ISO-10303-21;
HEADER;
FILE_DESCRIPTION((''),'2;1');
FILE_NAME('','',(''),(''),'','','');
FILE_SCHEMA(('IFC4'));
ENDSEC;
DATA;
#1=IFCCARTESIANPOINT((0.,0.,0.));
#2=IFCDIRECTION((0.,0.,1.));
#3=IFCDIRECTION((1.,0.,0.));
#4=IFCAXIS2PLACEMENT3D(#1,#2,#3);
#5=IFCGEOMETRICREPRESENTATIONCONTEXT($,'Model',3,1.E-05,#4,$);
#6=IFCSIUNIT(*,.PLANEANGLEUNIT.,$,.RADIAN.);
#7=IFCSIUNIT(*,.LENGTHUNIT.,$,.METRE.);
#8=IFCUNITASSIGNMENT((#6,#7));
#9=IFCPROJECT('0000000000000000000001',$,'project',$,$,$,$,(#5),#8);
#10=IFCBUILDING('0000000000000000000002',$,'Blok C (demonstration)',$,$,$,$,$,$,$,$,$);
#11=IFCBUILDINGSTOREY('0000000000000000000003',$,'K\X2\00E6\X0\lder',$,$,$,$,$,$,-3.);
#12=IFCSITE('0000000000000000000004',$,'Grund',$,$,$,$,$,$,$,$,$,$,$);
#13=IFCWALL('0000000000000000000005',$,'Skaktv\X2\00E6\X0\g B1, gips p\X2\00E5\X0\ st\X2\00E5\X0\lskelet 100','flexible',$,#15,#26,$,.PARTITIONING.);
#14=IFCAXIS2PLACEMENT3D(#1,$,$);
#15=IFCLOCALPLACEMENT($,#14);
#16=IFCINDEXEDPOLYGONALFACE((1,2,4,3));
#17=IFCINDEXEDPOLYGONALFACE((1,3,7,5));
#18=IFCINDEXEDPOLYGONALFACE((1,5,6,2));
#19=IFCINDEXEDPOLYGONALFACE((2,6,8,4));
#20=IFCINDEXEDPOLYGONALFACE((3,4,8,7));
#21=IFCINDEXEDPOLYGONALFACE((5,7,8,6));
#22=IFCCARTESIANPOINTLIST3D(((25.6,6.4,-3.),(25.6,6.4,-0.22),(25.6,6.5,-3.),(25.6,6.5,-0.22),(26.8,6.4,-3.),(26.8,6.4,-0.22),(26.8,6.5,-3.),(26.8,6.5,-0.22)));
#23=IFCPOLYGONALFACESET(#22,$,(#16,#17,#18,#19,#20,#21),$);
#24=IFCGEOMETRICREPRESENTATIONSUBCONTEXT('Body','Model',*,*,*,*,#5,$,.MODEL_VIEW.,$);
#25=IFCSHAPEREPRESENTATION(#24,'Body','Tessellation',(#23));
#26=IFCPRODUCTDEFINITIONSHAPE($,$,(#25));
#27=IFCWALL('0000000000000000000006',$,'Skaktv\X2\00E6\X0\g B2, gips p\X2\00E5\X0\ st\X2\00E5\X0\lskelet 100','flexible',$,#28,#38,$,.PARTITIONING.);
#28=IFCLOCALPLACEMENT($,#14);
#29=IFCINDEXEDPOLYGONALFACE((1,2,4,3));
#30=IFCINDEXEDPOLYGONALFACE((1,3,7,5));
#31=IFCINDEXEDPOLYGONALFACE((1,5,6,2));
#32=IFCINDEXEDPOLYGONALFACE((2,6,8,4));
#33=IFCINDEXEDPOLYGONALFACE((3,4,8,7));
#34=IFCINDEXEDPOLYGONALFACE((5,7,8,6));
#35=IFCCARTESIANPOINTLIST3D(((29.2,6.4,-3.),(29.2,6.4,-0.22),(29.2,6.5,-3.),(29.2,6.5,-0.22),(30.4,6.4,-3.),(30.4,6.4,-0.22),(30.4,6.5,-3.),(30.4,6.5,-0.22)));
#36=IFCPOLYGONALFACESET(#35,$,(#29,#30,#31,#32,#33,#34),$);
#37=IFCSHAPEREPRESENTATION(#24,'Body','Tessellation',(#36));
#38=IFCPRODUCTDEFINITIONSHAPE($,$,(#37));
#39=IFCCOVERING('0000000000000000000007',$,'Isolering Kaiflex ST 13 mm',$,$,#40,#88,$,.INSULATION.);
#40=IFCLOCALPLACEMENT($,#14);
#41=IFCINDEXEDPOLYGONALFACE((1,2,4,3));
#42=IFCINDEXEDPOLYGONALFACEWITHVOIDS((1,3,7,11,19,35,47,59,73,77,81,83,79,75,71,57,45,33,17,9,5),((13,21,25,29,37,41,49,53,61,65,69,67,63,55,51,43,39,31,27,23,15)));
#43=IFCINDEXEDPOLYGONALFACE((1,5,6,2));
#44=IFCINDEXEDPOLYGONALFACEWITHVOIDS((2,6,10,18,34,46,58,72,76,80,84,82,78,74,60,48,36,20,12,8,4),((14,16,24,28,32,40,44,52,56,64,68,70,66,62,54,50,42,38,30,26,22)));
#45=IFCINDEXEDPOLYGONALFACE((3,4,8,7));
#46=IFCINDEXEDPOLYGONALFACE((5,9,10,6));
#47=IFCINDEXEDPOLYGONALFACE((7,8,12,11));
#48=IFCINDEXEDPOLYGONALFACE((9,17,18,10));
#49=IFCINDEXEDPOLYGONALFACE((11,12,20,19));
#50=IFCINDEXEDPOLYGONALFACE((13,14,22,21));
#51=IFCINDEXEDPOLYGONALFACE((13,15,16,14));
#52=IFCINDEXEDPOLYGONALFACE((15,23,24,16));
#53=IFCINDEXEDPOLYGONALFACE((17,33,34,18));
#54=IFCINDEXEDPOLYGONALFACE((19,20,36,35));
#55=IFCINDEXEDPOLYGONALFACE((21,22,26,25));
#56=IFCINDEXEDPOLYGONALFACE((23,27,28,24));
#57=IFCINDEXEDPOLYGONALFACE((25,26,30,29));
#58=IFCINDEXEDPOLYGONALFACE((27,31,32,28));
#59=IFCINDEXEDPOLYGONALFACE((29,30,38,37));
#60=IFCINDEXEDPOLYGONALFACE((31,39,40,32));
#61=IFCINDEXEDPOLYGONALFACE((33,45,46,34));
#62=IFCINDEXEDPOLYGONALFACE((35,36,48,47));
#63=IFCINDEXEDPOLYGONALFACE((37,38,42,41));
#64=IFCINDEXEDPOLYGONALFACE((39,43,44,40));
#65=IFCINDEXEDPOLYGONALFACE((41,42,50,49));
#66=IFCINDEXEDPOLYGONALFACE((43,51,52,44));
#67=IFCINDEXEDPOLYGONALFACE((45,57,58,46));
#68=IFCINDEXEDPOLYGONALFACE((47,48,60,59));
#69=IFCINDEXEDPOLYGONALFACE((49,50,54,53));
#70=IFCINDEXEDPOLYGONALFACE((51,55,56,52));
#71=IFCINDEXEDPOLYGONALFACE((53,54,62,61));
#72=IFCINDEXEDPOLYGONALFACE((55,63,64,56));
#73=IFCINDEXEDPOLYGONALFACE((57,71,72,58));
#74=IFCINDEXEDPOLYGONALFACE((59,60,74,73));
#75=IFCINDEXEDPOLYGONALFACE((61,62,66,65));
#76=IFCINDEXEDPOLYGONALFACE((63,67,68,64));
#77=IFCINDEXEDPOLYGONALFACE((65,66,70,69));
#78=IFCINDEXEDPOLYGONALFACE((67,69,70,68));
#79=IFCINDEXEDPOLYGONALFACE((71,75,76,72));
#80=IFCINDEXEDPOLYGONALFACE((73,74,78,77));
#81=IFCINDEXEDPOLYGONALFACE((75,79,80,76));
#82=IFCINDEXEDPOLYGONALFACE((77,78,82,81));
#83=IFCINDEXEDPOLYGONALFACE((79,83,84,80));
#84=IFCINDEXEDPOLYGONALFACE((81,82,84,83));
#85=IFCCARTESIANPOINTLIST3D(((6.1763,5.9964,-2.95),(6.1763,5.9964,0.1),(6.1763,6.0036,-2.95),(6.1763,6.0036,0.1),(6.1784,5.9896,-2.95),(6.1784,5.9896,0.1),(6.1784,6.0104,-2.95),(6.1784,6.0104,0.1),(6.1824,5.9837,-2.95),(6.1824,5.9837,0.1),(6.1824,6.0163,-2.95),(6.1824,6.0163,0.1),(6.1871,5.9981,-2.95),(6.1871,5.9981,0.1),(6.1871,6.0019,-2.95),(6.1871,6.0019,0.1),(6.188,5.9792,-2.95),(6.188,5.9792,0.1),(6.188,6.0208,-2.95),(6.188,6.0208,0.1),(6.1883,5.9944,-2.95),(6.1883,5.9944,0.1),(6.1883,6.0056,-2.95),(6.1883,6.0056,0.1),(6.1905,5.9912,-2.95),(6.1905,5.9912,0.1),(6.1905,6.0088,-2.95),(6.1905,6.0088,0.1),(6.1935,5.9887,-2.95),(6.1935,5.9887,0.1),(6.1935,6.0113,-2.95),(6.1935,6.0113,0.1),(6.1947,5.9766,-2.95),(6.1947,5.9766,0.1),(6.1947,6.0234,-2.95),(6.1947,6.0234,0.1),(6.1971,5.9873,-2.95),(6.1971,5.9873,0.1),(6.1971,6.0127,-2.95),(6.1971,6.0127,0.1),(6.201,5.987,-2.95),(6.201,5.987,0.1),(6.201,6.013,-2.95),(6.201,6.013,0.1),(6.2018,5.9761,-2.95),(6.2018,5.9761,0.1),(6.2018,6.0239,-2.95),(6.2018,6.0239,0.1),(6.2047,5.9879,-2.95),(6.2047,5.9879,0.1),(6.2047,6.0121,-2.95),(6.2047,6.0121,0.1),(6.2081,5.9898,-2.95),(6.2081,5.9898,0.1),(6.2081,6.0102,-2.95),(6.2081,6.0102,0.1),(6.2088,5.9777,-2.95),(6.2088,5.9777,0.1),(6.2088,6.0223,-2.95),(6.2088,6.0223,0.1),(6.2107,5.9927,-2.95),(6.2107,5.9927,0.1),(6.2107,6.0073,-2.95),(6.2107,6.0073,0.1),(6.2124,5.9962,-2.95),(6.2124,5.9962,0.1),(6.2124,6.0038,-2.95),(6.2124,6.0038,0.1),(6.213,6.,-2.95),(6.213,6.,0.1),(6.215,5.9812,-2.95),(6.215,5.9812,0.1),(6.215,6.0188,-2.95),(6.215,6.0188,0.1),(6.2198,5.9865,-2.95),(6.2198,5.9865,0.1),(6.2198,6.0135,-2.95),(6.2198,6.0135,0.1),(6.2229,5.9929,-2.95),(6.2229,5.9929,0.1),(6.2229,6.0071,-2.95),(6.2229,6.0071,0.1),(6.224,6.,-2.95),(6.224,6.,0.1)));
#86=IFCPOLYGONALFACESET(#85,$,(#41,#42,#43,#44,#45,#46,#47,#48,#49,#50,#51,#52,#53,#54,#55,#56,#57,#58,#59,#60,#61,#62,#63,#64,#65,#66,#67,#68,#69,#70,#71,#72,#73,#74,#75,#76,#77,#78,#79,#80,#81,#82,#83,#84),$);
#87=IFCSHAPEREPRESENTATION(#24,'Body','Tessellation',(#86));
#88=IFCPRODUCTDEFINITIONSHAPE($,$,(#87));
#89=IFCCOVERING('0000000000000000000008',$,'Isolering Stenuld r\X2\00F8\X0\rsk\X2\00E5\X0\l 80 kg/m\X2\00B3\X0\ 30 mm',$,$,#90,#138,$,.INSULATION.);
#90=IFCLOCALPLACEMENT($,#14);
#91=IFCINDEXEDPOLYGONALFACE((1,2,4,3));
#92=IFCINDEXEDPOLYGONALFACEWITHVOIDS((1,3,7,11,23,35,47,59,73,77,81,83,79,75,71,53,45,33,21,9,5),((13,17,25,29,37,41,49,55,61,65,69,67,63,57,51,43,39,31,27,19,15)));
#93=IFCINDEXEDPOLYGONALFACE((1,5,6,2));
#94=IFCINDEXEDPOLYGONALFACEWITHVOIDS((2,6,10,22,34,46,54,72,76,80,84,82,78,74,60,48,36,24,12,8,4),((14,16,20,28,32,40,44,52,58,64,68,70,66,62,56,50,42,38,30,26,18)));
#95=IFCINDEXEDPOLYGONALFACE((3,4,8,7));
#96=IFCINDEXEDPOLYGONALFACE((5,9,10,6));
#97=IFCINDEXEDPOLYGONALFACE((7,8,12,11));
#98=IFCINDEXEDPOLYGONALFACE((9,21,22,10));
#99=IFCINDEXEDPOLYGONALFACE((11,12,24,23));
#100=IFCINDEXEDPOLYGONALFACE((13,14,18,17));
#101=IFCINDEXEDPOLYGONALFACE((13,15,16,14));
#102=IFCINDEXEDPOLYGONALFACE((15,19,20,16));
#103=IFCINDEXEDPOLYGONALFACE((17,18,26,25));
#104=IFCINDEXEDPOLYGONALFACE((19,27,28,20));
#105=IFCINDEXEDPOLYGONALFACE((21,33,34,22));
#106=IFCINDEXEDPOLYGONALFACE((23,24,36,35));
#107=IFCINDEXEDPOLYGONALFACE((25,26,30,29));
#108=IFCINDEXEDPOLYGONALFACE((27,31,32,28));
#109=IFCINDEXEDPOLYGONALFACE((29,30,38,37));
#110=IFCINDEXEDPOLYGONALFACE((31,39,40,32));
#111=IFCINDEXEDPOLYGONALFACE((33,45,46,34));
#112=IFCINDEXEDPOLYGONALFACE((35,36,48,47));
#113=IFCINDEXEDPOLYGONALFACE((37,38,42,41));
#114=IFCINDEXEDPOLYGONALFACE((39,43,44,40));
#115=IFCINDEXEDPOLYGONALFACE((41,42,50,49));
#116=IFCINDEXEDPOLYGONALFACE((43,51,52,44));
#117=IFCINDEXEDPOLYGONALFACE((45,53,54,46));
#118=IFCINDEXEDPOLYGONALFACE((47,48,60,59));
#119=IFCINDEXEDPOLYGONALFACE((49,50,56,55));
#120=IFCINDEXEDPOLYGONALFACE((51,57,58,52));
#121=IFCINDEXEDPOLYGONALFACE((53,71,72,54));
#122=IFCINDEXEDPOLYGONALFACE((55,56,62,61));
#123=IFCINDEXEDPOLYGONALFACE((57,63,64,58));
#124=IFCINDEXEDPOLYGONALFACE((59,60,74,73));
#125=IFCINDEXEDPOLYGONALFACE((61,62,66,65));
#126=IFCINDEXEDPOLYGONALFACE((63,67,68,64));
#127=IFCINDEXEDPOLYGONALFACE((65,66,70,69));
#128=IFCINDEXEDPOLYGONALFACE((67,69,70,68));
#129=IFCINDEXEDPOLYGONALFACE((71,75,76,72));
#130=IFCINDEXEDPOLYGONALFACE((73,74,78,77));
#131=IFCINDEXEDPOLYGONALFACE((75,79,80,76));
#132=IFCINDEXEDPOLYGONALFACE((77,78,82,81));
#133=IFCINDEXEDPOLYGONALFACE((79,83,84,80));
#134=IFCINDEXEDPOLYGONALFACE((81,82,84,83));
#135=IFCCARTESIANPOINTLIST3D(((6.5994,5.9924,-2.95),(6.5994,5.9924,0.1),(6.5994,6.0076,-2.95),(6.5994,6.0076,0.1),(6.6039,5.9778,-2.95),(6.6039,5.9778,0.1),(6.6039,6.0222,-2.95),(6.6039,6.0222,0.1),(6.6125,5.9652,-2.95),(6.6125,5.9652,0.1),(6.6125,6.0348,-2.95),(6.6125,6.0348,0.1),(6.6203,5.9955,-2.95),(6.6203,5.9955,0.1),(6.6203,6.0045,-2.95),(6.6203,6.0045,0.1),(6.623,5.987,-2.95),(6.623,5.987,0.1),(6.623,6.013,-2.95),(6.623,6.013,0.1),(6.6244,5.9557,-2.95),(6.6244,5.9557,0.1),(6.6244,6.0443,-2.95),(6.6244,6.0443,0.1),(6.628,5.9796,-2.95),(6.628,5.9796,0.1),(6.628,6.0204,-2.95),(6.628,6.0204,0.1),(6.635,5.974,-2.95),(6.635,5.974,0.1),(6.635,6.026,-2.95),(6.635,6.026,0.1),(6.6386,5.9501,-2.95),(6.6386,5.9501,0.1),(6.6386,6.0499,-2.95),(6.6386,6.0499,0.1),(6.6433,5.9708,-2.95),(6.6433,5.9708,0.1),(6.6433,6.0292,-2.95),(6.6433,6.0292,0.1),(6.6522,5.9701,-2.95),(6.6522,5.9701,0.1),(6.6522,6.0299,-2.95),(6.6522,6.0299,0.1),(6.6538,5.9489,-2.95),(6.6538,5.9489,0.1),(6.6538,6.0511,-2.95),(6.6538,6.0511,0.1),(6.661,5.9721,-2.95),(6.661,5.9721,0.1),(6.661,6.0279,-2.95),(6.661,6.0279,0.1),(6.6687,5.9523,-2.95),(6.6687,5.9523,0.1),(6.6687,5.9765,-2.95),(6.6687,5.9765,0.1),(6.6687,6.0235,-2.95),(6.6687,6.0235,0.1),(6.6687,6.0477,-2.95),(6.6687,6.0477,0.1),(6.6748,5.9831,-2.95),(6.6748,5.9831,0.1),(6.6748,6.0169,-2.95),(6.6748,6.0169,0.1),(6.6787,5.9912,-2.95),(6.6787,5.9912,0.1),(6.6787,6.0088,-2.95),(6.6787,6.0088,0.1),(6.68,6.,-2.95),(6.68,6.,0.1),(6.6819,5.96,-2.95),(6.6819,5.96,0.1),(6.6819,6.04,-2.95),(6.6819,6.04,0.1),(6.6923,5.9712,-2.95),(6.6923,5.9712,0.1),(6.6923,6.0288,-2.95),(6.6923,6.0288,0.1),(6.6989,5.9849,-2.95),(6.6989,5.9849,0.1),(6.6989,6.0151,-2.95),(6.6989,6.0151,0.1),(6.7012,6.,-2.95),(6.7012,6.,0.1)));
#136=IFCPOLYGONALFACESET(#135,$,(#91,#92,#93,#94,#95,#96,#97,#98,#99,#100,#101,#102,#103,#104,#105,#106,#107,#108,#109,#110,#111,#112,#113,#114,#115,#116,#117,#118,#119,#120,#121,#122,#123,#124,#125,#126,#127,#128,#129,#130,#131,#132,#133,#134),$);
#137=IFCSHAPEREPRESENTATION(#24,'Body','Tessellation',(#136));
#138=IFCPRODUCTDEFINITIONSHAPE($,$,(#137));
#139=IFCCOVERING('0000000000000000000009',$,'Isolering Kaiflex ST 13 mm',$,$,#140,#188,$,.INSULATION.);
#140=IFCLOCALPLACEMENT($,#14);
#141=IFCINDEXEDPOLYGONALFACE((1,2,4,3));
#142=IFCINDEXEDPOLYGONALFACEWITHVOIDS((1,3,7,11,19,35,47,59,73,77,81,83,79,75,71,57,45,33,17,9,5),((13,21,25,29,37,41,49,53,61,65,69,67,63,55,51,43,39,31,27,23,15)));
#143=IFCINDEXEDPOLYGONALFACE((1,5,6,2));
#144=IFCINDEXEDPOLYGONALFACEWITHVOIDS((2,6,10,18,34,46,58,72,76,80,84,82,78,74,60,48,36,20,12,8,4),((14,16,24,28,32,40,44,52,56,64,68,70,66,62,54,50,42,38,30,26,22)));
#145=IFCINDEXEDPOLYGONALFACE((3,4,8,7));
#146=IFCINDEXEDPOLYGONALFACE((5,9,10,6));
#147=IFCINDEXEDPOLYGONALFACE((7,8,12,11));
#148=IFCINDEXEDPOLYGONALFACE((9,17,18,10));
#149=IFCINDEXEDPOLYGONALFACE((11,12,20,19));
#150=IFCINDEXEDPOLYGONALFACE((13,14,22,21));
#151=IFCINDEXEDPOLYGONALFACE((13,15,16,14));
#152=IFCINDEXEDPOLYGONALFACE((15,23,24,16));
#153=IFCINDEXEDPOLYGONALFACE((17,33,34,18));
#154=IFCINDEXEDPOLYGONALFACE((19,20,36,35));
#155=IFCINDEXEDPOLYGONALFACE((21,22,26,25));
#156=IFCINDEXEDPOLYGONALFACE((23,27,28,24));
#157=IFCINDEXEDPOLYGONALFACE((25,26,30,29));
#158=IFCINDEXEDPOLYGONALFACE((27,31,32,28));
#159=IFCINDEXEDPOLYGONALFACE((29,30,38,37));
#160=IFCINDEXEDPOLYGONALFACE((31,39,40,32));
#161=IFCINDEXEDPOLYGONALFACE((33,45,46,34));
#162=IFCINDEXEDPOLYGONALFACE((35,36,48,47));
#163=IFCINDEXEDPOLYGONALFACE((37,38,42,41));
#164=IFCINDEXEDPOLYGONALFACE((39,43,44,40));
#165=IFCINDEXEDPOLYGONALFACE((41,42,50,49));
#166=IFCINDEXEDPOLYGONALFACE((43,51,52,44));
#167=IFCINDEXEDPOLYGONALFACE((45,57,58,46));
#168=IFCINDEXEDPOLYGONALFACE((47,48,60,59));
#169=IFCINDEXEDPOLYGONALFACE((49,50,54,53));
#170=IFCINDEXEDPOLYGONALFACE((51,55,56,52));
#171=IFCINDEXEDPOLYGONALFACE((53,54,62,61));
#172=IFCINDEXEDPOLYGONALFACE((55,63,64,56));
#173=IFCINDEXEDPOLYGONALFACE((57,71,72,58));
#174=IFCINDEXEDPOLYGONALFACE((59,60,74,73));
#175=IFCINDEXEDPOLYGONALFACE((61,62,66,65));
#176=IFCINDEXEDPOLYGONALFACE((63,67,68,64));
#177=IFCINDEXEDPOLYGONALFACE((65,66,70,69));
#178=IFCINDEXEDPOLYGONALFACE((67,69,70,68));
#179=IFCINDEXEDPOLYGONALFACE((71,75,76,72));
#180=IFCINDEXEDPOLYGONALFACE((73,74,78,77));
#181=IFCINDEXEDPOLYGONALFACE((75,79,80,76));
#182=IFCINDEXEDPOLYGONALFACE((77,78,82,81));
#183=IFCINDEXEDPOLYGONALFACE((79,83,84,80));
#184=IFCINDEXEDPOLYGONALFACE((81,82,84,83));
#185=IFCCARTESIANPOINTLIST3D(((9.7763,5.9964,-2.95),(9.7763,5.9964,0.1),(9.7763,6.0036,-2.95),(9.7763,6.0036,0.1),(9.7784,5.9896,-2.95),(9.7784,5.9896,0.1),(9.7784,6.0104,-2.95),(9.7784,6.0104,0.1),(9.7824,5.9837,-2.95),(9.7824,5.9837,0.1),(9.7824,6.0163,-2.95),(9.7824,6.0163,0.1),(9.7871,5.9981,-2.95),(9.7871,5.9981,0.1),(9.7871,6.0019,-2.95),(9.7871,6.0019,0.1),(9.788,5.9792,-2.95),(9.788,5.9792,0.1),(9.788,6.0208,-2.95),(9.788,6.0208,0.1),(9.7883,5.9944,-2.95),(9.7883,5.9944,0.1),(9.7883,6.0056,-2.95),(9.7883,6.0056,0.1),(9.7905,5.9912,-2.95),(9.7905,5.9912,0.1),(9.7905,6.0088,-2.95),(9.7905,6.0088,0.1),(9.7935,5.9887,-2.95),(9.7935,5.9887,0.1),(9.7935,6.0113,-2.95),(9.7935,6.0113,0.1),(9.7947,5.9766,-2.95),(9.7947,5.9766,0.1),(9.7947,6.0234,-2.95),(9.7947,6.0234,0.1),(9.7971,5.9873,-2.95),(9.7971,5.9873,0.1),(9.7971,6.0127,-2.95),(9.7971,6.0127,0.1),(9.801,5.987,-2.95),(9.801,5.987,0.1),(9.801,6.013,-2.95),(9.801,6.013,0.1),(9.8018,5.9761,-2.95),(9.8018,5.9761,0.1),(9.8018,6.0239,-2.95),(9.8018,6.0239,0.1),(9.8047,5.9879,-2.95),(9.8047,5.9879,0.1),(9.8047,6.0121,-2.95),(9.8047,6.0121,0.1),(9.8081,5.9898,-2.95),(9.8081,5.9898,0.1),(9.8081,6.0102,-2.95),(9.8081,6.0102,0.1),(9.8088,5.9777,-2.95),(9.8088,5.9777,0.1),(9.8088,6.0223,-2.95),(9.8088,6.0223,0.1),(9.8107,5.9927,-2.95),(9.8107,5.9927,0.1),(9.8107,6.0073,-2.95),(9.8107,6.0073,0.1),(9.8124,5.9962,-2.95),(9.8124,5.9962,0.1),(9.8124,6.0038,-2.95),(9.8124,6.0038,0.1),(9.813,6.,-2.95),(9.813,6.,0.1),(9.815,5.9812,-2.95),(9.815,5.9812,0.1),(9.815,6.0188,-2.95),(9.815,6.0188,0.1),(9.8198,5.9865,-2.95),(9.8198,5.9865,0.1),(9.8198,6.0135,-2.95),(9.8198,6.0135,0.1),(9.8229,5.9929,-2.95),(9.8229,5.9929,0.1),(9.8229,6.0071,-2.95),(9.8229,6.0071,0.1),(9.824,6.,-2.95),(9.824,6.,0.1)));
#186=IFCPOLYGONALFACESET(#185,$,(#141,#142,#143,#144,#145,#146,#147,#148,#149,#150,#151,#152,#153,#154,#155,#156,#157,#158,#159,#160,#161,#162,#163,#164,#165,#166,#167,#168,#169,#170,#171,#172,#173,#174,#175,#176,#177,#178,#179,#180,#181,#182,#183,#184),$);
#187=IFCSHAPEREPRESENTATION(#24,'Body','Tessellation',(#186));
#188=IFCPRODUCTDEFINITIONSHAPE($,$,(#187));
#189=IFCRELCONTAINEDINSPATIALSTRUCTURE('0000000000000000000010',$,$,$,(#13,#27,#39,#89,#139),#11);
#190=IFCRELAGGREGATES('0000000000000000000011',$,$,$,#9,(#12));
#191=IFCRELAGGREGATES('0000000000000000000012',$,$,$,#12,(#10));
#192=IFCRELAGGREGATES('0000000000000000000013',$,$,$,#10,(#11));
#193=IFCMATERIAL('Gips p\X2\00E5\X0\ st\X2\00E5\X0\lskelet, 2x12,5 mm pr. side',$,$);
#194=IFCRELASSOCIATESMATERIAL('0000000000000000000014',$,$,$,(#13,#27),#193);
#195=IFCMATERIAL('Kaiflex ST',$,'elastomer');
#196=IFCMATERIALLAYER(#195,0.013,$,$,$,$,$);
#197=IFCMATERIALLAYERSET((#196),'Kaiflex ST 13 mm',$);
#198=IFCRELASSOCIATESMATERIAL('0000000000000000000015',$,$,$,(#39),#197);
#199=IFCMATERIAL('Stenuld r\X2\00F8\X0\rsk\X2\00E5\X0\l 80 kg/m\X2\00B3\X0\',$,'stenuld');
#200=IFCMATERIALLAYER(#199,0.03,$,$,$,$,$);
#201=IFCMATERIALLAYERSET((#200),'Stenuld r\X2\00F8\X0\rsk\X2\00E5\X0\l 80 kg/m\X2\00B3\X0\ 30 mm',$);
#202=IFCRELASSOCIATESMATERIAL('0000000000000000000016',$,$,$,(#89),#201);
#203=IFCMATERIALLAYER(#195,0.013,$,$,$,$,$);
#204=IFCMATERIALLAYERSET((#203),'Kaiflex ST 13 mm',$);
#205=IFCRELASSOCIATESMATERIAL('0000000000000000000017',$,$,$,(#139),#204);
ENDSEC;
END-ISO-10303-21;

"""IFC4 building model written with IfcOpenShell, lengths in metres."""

from ifc_helpers import new_model, si_unit, frame, origin_with_axes, place, context, subcontext, project, spatial, polyline, hollow_circle, outline, extrude, material, layer, layer_set, element, save


model = new_model("IFC4")

# Units and contexts
model_context = context("Model", 3, precision=1e-05, world=origin_with_axes())
body_context = subcontext(model_context, "Body", "Model", "MODEL_VIEW")
ifc_project = project(units=[si_unit("PLANEANGLEUNIT", "RADIAN"), si_unit("LENGTHUNIT", "METRE")], contexts=[model_context])

# Site, building, storey
site = spatial("IfcSite", under=ifc_project, Name="Grund")
building = spatial("IfcBuilding", under=site, Name="Blok C (demonstration)")
storey = spatial("IfcBuildingStorey", under=building, Name="Kælder", Elevation=-3.0)

# Shared definitions
ifc_material_1 = material(Name="Gips på stålskelet, 2x12,5 mm pr. side")

# Walls
wall_1_placement = place(None, origin_with_axes())
element("IfcWall", 1, at=wall_1_placement, inside=storey, material=ifc_material_1, Name="Skaktvæg B1, gips på stålskelet 100", Description="flexible", PredefinedType="PARTITIONING", context=body_context, shape_type="SweptSolid", body=[
    extrude(outline(polyline([(25.6, 6.4), (26.8, 6.4), (26.8, 6.5), (25.6, 6.5), (25.6, 6.4)])), frame((0.0, 0.0, -3.0)), (0.0, 0.0, 1.0), 2.78),
])
wall_2_placement = place(None, origin_with_axes())
element("IfcWall", 2, at=wall_2_placement, inside=storey, material=ifc_material_1, Name="Skaktvæg B2, gips på stålskelet 100", Description="flexible", PredefinedType="PARTITIONING", context=body_context, shape_type="SweptSolid", body=[
    extrude(outline(polyline([(29.2, 6.4), (30.4, 6.4), (30.4, 6.5), (29.2, 6.5), (29.2, 6.4)])), frame((0.0, 0.0, -3.0)), (0.0, 0.0, 1.0), 2.78),
])

# Coverings
ifc_material_2 = material(Name="Kaiflex ST", Category="elastomer")
ifc_layer_1 = layer(ifc_material_2, 0.013)
ifc_layer_set_1 = layer_set([ifc_layer_1], Name="Kaiflex ST 13 mm")
covering_1_placement = place(None, origin_with_axes())
element("IfcCovering", 3, at=covering_1_placement, inside=storey, material=ifc_layer_set_1, Name="Isolering Kaiflex ST 13 mm", PredefinedType="INSULATION", context=body_context, shape_type="SweptSolid", body=[
    extrude(hollow_circle(Radius=0.024, WallThickness=0.011), frame((6.2, 6.0, -2.95), z_axis=(0.0, 0.0, 1.0), x_axis=(1.0, 0.0, 0.0)), (0.0, 0.0, 1.0), 3.05),
])
ifc_material_3 = material(Name="Stenuld rørskål 80 kg/m³", Category="stenuld")
ifc_layer_2 = layer(ifc_material_3, 0.03)
ifc_layer_set_2 = layer_set([ifc_layer_2], Name="Stenuld rørskål 80 kg/m³ 30 mm")
covering_2_placement = place(None, origin_with_axes())
element("IfcCovering", 4, at=covering_2_placement, inside=storey, material=ifc_layer_set_2, Name="Isolering Stenuld rørskål 80 kg/m³ 30 mm", PredefinedType="INSULATION", context=body_context, shape_type="SweptSolid", body=[
    extrude(hollow_circle(Radius=0.0512, WallThickness=0.0212), frame((6.65, 6.0, -2.95), z_axis=(0.0, 0.0, 1.0), x_axis=(1.0, 0.0, 0.0)), (0.0, 0.0, 1.0), 3.05),
])
ifc_layer_3 = layer(ifc_material_2, 0.013)
ifc_layer_set_3 = layer_set([ifc_layer_3], Name="Kaiflex ST 13 mm")
covering_3_placement = place(None, origin_with_axes())
element("IfcCovering", 5, at=covering_3_placement, inside=storey, material=ifc_layer_set_3, Name="Isolering Kaiflex ST 13 mm", PredefinedType="INSULATION", context=body_context, shape_type="SweptSolid", body=[
    extrude(hollow_circle(Radius=0.024, WallThickness=0.011), frame((9.8, 6.0, -2.95), z_axis=(0.0, 0.0, 1.0), x_axis=(1.0, 0.0, 0.0)), (0.0, 0.0, 1.0), 3.05),
])

save(model, "model.ifc")
